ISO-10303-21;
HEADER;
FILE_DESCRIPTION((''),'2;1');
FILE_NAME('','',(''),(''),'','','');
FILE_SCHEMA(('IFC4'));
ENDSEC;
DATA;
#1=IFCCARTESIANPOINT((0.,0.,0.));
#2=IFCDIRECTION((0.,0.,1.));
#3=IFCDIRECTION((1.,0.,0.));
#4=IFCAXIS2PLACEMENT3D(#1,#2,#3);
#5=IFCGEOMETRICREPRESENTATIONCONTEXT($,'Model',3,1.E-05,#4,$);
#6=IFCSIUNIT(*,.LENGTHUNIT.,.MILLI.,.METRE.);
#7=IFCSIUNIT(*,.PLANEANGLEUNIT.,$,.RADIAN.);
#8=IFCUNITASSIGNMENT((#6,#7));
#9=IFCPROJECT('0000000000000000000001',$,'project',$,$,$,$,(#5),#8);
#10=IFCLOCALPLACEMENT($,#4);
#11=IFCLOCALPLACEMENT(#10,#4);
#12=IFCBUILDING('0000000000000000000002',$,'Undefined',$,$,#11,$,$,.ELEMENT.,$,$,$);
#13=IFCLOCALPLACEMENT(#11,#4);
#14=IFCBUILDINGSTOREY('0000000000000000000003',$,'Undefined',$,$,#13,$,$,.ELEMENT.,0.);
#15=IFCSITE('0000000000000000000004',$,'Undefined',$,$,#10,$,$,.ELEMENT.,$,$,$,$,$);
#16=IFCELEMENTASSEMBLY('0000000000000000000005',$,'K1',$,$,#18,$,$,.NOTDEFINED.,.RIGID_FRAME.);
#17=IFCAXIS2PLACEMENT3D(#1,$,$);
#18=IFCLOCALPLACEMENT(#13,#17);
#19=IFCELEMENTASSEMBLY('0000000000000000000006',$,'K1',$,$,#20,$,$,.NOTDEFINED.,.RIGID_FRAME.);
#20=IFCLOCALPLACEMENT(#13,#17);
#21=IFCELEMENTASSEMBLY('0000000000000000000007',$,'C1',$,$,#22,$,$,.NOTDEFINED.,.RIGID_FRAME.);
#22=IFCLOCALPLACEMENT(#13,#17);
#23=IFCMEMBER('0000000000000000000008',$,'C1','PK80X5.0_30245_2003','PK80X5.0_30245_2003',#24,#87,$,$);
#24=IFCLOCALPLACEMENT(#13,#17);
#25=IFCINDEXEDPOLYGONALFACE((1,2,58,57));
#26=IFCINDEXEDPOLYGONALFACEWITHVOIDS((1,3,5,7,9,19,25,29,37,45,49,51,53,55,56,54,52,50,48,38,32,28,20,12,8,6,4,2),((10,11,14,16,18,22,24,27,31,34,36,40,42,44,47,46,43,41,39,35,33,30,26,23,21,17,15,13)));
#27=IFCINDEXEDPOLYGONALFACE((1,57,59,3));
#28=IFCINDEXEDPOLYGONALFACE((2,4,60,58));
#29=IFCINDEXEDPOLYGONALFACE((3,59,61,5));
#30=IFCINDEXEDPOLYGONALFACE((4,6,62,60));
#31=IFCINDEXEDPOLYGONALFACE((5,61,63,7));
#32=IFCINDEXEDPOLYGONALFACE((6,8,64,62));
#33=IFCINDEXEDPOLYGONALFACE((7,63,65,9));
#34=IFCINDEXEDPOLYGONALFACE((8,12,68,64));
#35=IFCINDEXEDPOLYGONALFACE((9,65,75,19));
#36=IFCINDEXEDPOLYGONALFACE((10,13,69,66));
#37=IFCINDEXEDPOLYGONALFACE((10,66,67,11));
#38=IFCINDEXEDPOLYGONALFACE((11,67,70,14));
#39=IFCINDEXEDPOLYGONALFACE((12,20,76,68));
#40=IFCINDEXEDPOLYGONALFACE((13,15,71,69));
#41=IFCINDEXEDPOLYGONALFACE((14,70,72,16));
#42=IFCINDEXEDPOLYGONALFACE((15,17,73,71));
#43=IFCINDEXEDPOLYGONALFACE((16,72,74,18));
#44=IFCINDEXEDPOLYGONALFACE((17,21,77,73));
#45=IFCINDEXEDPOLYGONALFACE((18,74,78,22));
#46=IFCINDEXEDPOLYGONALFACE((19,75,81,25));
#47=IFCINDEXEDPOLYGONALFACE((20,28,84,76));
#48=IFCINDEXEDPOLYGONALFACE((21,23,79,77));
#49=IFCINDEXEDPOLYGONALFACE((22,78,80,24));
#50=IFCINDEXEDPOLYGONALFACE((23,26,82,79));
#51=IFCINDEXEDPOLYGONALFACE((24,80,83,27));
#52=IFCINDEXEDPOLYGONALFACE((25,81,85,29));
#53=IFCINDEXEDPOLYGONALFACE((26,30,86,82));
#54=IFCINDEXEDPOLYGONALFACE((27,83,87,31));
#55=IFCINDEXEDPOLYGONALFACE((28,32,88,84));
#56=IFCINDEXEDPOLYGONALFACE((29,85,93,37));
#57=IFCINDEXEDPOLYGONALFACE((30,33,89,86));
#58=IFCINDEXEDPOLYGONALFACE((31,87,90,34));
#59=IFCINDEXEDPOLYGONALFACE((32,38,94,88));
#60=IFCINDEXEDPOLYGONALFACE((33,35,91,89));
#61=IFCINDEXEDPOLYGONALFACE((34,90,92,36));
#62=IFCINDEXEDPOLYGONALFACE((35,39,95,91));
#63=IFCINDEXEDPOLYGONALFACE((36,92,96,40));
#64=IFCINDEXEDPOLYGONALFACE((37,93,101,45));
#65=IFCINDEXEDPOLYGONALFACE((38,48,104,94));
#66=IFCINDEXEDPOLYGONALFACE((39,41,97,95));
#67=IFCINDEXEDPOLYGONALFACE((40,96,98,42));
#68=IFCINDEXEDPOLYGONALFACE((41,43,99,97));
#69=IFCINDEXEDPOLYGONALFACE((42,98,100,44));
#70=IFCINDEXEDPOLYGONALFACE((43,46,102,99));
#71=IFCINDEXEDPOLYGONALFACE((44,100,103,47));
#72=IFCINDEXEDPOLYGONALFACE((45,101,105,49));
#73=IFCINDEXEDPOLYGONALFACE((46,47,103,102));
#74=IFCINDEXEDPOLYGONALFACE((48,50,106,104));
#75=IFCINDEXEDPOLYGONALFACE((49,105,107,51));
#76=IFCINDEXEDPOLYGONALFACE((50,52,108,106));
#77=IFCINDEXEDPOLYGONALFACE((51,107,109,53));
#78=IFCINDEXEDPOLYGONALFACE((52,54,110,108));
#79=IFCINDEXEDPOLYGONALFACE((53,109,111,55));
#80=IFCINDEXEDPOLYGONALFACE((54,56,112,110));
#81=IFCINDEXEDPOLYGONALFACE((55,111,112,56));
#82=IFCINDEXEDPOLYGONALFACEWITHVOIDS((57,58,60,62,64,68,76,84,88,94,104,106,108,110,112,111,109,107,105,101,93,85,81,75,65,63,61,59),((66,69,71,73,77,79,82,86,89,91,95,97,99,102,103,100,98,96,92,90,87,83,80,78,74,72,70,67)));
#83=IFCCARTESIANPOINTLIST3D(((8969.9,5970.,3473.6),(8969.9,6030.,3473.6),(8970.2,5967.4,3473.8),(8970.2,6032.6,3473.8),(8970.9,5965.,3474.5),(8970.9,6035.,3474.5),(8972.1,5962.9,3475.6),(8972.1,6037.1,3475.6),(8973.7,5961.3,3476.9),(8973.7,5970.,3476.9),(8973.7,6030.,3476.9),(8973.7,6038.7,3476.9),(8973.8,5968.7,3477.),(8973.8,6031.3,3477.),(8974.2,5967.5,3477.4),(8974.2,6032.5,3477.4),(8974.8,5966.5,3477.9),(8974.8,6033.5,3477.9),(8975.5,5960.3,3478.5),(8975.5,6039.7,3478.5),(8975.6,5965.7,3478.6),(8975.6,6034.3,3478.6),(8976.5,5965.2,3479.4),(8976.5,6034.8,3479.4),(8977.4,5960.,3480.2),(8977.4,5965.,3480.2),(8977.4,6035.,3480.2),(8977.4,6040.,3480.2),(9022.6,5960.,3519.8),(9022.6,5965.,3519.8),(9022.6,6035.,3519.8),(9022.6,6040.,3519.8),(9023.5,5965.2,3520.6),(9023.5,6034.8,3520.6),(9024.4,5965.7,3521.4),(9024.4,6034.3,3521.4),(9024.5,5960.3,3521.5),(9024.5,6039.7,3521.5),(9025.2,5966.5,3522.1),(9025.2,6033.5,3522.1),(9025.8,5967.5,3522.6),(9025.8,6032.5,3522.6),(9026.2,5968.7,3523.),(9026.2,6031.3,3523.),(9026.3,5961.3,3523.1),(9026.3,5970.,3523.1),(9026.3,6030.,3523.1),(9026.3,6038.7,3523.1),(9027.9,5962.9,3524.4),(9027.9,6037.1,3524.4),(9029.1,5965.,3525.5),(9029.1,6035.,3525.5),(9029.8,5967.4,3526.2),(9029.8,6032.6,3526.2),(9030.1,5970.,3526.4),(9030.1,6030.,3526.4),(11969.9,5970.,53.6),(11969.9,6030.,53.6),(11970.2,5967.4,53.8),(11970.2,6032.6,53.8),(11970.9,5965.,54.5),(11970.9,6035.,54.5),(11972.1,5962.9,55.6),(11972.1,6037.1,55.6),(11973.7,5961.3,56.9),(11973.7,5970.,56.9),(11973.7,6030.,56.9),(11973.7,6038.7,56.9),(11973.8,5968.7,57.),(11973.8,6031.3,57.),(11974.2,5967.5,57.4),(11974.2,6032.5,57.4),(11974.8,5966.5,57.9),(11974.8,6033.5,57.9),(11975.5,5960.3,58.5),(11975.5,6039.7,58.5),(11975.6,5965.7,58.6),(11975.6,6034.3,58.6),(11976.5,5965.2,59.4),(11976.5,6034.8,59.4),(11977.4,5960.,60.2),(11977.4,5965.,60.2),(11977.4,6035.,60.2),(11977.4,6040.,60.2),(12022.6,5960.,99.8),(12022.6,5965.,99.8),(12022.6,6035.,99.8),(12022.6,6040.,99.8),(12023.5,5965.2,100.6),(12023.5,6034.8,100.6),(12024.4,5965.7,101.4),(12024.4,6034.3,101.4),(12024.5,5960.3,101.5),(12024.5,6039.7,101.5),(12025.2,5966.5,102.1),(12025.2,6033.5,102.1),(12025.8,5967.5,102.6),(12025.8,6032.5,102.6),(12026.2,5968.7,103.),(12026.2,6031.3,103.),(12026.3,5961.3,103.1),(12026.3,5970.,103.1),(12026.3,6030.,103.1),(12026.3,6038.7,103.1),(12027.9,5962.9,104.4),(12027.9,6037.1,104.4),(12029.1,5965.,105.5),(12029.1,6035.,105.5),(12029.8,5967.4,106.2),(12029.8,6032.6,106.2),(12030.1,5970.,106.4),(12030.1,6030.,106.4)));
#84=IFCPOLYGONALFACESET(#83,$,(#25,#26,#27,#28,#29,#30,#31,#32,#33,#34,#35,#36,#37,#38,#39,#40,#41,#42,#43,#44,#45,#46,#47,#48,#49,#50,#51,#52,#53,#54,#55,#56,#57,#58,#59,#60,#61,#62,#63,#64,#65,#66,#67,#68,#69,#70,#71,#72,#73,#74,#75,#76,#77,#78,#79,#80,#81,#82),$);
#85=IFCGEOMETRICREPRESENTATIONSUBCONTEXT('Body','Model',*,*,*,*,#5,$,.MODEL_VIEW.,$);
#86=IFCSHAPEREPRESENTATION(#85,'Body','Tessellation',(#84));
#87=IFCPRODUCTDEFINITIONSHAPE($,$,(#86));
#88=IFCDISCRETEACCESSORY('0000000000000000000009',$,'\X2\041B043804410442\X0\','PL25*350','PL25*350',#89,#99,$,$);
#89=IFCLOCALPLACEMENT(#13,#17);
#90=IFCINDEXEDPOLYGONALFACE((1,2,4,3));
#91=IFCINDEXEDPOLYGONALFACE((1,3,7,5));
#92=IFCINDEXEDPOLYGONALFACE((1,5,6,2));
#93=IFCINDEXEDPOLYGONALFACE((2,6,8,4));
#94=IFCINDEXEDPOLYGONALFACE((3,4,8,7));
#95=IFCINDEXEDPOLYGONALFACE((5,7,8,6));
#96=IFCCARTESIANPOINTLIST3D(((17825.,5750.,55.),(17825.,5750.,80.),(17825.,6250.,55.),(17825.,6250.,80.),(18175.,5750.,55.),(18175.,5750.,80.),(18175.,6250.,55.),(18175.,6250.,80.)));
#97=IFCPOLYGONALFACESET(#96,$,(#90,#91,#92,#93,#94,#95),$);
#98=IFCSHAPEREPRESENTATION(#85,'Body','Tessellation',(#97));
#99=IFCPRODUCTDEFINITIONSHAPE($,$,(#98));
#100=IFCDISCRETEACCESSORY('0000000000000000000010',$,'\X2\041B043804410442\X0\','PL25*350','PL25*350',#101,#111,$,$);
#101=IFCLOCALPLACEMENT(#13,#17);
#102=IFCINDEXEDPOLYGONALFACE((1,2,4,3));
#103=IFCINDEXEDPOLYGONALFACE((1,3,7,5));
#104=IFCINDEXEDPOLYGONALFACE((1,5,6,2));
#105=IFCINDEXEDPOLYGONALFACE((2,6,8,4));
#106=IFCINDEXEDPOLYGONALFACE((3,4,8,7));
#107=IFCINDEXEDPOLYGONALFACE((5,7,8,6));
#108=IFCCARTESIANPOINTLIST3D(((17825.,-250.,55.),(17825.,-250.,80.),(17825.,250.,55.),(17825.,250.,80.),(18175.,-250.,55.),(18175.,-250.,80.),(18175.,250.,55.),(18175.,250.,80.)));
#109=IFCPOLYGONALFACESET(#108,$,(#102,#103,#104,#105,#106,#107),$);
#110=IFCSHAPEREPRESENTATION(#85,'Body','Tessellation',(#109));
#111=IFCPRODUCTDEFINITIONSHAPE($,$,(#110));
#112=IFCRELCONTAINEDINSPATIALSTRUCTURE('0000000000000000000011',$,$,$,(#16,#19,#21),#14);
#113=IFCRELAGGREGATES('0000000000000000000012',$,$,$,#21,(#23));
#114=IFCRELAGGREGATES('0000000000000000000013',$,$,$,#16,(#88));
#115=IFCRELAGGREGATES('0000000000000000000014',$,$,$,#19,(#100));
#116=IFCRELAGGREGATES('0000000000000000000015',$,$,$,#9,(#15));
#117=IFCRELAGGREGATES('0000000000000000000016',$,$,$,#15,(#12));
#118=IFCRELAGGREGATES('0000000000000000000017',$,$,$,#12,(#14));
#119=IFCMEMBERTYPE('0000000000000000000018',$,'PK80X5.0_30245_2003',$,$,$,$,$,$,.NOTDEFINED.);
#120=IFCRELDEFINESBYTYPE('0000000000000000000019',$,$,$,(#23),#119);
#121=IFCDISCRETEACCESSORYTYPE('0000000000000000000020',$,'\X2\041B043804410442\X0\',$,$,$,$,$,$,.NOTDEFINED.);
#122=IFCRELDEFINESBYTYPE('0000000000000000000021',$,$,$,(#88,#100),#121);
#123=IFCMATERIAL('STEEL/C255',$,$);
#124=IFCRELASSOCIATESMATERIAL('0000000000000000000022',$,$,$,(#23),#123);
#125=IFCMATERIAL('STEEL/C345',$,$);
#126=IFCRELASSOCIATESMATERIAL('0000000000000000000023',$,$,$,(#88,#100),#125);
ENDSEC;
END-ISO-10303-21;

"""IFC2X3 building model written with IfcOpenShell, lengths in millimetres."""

from ifc_helpers import new_model, si_unit, frame, origin_with_axes, origin_2d_with_axis, place, context, subcontext, project, spatial, polyline, hollow_rectangle, outline, extrude, material, type_object, element, aggregate, save


model = new_model("IFC2X3")

# Units and contexts
model_context = context("Model", 3, precision=1e-05, world=origin_with_axes())
body_context = subcontext(model_context, "Body", "Model", "MODEL_VIEW")
ifc_project = project(units=[si_unit("LENGTHUNIT", "METRE", prefix="MILLI"), si_unit("PLANEANGLEUNIT", "RADIAN")], contexts=[model_context])

# Site, building, storey
site_placement = place(None, origin_with_axes())
site = spatial("IfcSite", under=ifc_project, at=site_placement, Name="Undefined", CompositionType="ELEMENT")
building_placement = place(site_placement, origin_with_axes())
building = spatial("IfcBuilding", under=site, at=building_placement, Name="Undefined", CompositionType="ELEMENT")
storey_placement = place(building_placement, origin_with_axes())
storey = spatial("IfcBuildingStorey", under=building, at=storey_placement, Name="Undefined", CompositionType="ELEMENT", Elevation=0.0)

# Element assemblies
assembly_1_placement = place(storey_placement, origin_with_axes())
assembly_1 = element("IfcElementAssembly", 1, at=assembly_1_placement, inside=storey, Name="K1", AssemblyPlace="NOTDEFINED", PredefinedType="RIGID_FRAME")
ifc_material_1 = material(Name="STEEL/C345")
assembly_2_placement = place(storey_placement, origin_with_axes())
assembly_2 = element("IfcElementAssembly", 2, at=assembly_2_placement, inside=storey, Name="K1", AssemblyPlace="NOTDEFINED", PredefinedType="RIGID_FRAME")

# Shared definitions
ifc_material_2 = material(Name="STEEL/C255")

# Element assembly, member
member_type = type_object("IfcMemberType", Name="PK80X5.0_30245_2003", PredefinedType="NOTDEFINED")
assembly_3_placement = place(storey_placement, origin_with_axes())
assembly_3 = element("IfcElementAssembly", 3, at=assembly_3_placement, inside=storey, Name="C1", AssemblyPlace="NOTDEFINED", PredefinedType="RIGID_FRAME")
member_1_placement = place(assembly_3_placement, frame((12000.0, 6000.0, 80.0), z_axis=(-0.751759, 0.0, -0.659438), x_axis=(-0.659438, 0.0, 0.751759)))
member_1 = element("IfcMember", 4, at=member_1_placement, type_object=member_type, material=ifc_material_2, Name="C1", Description="PK80X5.0_30245_2003", ObjectType="PK80X5.0_30245_2003", context=body_context, shape_type="SweptSolid", body=[
    extrude(hollow_rectangle(XDim=80.0, YDim=80.0, WallThickness=5.0, InnerFilletRadius=5.0, OuterFilletRadius=10.0, at=origin_2d_with_axis()), frame((4549.3, 0.0, 0.0), z_axis=(-1.0, 0.0, 0.0), x_axis=(0.0, -1.0, 0.0)), (0.0, 0.0, 1.0), 4549.3),
])
aggregate(assembly_3, [member_1])

# Discrete accessories
discrete_accessory_type = type_object("IfcDiscreteAccessoryType", Name="Лист")
discrete_accessory_1_placement = place(assembly_1_placement, frame((17825.0, 6250.0, 67.5), z_axis=(0.0, 0.0, 1.0), x_axis=(0.0, -1.0, 0.0)))
discrete_accessory_1 = element("IfcDiscreteAccessory", 5, at=discrete_accessory_1_placement, type_object=discrete_accessory_type, material=ifc_material_1, Name="Лист", Description="PL25*350", ObjectType="PL25*350", context=body_context, shape_type="SweptSolid", body=[
    extrude(outline(polyline([(0.0, 0.0), (500.0, 0.0), (500.0, 350.0), (0.0, 350.0), (0.0, 0.0)])), frame((0.0, 0.0, -12.5), z_axis=(0.0, 0.0, 1.0), x_axis=(1.0, 0.0, 0.0)), (0.0, 0.0, 1.0), 25.0),
])
aggregate(assembly_1, [discrete_accessory_1])
discrete_accessory_2_placement = place(assembly_2_placement, frame((17825.0, 250.0, 67.5), z_axis=(0.0, 0.0, 1.0), x_axis=(0.0, -1.0, 0.0)))
discrete_accessory_2 = element("IfcDiscreteAccessory", 6, at=discrete_accessory_2_placement, type_object=discrete_accessory_type, material=ifc_material_1, Name="Лист", Description="PL25*350", ObjectType="PL25*350", context=body_context, shape_type="SweptSolid", body=[
    extrude(outline(polyline([(0.0, 0.0), (500.0, 0.0), (500.0, 350.0), (0.0, 350.0), (0.0, 0.0)])), frame((0.0, 0.0, -12.5), z_axis=(0.0, 0.0, 1.0), x_axis=(1.0, 0.0, 0.0)), (0.0, 0.0, 1.0), 25.0),
])
aggregate(assembly_2, [discrete_accessory_2])

save(model, "model.ifc")
